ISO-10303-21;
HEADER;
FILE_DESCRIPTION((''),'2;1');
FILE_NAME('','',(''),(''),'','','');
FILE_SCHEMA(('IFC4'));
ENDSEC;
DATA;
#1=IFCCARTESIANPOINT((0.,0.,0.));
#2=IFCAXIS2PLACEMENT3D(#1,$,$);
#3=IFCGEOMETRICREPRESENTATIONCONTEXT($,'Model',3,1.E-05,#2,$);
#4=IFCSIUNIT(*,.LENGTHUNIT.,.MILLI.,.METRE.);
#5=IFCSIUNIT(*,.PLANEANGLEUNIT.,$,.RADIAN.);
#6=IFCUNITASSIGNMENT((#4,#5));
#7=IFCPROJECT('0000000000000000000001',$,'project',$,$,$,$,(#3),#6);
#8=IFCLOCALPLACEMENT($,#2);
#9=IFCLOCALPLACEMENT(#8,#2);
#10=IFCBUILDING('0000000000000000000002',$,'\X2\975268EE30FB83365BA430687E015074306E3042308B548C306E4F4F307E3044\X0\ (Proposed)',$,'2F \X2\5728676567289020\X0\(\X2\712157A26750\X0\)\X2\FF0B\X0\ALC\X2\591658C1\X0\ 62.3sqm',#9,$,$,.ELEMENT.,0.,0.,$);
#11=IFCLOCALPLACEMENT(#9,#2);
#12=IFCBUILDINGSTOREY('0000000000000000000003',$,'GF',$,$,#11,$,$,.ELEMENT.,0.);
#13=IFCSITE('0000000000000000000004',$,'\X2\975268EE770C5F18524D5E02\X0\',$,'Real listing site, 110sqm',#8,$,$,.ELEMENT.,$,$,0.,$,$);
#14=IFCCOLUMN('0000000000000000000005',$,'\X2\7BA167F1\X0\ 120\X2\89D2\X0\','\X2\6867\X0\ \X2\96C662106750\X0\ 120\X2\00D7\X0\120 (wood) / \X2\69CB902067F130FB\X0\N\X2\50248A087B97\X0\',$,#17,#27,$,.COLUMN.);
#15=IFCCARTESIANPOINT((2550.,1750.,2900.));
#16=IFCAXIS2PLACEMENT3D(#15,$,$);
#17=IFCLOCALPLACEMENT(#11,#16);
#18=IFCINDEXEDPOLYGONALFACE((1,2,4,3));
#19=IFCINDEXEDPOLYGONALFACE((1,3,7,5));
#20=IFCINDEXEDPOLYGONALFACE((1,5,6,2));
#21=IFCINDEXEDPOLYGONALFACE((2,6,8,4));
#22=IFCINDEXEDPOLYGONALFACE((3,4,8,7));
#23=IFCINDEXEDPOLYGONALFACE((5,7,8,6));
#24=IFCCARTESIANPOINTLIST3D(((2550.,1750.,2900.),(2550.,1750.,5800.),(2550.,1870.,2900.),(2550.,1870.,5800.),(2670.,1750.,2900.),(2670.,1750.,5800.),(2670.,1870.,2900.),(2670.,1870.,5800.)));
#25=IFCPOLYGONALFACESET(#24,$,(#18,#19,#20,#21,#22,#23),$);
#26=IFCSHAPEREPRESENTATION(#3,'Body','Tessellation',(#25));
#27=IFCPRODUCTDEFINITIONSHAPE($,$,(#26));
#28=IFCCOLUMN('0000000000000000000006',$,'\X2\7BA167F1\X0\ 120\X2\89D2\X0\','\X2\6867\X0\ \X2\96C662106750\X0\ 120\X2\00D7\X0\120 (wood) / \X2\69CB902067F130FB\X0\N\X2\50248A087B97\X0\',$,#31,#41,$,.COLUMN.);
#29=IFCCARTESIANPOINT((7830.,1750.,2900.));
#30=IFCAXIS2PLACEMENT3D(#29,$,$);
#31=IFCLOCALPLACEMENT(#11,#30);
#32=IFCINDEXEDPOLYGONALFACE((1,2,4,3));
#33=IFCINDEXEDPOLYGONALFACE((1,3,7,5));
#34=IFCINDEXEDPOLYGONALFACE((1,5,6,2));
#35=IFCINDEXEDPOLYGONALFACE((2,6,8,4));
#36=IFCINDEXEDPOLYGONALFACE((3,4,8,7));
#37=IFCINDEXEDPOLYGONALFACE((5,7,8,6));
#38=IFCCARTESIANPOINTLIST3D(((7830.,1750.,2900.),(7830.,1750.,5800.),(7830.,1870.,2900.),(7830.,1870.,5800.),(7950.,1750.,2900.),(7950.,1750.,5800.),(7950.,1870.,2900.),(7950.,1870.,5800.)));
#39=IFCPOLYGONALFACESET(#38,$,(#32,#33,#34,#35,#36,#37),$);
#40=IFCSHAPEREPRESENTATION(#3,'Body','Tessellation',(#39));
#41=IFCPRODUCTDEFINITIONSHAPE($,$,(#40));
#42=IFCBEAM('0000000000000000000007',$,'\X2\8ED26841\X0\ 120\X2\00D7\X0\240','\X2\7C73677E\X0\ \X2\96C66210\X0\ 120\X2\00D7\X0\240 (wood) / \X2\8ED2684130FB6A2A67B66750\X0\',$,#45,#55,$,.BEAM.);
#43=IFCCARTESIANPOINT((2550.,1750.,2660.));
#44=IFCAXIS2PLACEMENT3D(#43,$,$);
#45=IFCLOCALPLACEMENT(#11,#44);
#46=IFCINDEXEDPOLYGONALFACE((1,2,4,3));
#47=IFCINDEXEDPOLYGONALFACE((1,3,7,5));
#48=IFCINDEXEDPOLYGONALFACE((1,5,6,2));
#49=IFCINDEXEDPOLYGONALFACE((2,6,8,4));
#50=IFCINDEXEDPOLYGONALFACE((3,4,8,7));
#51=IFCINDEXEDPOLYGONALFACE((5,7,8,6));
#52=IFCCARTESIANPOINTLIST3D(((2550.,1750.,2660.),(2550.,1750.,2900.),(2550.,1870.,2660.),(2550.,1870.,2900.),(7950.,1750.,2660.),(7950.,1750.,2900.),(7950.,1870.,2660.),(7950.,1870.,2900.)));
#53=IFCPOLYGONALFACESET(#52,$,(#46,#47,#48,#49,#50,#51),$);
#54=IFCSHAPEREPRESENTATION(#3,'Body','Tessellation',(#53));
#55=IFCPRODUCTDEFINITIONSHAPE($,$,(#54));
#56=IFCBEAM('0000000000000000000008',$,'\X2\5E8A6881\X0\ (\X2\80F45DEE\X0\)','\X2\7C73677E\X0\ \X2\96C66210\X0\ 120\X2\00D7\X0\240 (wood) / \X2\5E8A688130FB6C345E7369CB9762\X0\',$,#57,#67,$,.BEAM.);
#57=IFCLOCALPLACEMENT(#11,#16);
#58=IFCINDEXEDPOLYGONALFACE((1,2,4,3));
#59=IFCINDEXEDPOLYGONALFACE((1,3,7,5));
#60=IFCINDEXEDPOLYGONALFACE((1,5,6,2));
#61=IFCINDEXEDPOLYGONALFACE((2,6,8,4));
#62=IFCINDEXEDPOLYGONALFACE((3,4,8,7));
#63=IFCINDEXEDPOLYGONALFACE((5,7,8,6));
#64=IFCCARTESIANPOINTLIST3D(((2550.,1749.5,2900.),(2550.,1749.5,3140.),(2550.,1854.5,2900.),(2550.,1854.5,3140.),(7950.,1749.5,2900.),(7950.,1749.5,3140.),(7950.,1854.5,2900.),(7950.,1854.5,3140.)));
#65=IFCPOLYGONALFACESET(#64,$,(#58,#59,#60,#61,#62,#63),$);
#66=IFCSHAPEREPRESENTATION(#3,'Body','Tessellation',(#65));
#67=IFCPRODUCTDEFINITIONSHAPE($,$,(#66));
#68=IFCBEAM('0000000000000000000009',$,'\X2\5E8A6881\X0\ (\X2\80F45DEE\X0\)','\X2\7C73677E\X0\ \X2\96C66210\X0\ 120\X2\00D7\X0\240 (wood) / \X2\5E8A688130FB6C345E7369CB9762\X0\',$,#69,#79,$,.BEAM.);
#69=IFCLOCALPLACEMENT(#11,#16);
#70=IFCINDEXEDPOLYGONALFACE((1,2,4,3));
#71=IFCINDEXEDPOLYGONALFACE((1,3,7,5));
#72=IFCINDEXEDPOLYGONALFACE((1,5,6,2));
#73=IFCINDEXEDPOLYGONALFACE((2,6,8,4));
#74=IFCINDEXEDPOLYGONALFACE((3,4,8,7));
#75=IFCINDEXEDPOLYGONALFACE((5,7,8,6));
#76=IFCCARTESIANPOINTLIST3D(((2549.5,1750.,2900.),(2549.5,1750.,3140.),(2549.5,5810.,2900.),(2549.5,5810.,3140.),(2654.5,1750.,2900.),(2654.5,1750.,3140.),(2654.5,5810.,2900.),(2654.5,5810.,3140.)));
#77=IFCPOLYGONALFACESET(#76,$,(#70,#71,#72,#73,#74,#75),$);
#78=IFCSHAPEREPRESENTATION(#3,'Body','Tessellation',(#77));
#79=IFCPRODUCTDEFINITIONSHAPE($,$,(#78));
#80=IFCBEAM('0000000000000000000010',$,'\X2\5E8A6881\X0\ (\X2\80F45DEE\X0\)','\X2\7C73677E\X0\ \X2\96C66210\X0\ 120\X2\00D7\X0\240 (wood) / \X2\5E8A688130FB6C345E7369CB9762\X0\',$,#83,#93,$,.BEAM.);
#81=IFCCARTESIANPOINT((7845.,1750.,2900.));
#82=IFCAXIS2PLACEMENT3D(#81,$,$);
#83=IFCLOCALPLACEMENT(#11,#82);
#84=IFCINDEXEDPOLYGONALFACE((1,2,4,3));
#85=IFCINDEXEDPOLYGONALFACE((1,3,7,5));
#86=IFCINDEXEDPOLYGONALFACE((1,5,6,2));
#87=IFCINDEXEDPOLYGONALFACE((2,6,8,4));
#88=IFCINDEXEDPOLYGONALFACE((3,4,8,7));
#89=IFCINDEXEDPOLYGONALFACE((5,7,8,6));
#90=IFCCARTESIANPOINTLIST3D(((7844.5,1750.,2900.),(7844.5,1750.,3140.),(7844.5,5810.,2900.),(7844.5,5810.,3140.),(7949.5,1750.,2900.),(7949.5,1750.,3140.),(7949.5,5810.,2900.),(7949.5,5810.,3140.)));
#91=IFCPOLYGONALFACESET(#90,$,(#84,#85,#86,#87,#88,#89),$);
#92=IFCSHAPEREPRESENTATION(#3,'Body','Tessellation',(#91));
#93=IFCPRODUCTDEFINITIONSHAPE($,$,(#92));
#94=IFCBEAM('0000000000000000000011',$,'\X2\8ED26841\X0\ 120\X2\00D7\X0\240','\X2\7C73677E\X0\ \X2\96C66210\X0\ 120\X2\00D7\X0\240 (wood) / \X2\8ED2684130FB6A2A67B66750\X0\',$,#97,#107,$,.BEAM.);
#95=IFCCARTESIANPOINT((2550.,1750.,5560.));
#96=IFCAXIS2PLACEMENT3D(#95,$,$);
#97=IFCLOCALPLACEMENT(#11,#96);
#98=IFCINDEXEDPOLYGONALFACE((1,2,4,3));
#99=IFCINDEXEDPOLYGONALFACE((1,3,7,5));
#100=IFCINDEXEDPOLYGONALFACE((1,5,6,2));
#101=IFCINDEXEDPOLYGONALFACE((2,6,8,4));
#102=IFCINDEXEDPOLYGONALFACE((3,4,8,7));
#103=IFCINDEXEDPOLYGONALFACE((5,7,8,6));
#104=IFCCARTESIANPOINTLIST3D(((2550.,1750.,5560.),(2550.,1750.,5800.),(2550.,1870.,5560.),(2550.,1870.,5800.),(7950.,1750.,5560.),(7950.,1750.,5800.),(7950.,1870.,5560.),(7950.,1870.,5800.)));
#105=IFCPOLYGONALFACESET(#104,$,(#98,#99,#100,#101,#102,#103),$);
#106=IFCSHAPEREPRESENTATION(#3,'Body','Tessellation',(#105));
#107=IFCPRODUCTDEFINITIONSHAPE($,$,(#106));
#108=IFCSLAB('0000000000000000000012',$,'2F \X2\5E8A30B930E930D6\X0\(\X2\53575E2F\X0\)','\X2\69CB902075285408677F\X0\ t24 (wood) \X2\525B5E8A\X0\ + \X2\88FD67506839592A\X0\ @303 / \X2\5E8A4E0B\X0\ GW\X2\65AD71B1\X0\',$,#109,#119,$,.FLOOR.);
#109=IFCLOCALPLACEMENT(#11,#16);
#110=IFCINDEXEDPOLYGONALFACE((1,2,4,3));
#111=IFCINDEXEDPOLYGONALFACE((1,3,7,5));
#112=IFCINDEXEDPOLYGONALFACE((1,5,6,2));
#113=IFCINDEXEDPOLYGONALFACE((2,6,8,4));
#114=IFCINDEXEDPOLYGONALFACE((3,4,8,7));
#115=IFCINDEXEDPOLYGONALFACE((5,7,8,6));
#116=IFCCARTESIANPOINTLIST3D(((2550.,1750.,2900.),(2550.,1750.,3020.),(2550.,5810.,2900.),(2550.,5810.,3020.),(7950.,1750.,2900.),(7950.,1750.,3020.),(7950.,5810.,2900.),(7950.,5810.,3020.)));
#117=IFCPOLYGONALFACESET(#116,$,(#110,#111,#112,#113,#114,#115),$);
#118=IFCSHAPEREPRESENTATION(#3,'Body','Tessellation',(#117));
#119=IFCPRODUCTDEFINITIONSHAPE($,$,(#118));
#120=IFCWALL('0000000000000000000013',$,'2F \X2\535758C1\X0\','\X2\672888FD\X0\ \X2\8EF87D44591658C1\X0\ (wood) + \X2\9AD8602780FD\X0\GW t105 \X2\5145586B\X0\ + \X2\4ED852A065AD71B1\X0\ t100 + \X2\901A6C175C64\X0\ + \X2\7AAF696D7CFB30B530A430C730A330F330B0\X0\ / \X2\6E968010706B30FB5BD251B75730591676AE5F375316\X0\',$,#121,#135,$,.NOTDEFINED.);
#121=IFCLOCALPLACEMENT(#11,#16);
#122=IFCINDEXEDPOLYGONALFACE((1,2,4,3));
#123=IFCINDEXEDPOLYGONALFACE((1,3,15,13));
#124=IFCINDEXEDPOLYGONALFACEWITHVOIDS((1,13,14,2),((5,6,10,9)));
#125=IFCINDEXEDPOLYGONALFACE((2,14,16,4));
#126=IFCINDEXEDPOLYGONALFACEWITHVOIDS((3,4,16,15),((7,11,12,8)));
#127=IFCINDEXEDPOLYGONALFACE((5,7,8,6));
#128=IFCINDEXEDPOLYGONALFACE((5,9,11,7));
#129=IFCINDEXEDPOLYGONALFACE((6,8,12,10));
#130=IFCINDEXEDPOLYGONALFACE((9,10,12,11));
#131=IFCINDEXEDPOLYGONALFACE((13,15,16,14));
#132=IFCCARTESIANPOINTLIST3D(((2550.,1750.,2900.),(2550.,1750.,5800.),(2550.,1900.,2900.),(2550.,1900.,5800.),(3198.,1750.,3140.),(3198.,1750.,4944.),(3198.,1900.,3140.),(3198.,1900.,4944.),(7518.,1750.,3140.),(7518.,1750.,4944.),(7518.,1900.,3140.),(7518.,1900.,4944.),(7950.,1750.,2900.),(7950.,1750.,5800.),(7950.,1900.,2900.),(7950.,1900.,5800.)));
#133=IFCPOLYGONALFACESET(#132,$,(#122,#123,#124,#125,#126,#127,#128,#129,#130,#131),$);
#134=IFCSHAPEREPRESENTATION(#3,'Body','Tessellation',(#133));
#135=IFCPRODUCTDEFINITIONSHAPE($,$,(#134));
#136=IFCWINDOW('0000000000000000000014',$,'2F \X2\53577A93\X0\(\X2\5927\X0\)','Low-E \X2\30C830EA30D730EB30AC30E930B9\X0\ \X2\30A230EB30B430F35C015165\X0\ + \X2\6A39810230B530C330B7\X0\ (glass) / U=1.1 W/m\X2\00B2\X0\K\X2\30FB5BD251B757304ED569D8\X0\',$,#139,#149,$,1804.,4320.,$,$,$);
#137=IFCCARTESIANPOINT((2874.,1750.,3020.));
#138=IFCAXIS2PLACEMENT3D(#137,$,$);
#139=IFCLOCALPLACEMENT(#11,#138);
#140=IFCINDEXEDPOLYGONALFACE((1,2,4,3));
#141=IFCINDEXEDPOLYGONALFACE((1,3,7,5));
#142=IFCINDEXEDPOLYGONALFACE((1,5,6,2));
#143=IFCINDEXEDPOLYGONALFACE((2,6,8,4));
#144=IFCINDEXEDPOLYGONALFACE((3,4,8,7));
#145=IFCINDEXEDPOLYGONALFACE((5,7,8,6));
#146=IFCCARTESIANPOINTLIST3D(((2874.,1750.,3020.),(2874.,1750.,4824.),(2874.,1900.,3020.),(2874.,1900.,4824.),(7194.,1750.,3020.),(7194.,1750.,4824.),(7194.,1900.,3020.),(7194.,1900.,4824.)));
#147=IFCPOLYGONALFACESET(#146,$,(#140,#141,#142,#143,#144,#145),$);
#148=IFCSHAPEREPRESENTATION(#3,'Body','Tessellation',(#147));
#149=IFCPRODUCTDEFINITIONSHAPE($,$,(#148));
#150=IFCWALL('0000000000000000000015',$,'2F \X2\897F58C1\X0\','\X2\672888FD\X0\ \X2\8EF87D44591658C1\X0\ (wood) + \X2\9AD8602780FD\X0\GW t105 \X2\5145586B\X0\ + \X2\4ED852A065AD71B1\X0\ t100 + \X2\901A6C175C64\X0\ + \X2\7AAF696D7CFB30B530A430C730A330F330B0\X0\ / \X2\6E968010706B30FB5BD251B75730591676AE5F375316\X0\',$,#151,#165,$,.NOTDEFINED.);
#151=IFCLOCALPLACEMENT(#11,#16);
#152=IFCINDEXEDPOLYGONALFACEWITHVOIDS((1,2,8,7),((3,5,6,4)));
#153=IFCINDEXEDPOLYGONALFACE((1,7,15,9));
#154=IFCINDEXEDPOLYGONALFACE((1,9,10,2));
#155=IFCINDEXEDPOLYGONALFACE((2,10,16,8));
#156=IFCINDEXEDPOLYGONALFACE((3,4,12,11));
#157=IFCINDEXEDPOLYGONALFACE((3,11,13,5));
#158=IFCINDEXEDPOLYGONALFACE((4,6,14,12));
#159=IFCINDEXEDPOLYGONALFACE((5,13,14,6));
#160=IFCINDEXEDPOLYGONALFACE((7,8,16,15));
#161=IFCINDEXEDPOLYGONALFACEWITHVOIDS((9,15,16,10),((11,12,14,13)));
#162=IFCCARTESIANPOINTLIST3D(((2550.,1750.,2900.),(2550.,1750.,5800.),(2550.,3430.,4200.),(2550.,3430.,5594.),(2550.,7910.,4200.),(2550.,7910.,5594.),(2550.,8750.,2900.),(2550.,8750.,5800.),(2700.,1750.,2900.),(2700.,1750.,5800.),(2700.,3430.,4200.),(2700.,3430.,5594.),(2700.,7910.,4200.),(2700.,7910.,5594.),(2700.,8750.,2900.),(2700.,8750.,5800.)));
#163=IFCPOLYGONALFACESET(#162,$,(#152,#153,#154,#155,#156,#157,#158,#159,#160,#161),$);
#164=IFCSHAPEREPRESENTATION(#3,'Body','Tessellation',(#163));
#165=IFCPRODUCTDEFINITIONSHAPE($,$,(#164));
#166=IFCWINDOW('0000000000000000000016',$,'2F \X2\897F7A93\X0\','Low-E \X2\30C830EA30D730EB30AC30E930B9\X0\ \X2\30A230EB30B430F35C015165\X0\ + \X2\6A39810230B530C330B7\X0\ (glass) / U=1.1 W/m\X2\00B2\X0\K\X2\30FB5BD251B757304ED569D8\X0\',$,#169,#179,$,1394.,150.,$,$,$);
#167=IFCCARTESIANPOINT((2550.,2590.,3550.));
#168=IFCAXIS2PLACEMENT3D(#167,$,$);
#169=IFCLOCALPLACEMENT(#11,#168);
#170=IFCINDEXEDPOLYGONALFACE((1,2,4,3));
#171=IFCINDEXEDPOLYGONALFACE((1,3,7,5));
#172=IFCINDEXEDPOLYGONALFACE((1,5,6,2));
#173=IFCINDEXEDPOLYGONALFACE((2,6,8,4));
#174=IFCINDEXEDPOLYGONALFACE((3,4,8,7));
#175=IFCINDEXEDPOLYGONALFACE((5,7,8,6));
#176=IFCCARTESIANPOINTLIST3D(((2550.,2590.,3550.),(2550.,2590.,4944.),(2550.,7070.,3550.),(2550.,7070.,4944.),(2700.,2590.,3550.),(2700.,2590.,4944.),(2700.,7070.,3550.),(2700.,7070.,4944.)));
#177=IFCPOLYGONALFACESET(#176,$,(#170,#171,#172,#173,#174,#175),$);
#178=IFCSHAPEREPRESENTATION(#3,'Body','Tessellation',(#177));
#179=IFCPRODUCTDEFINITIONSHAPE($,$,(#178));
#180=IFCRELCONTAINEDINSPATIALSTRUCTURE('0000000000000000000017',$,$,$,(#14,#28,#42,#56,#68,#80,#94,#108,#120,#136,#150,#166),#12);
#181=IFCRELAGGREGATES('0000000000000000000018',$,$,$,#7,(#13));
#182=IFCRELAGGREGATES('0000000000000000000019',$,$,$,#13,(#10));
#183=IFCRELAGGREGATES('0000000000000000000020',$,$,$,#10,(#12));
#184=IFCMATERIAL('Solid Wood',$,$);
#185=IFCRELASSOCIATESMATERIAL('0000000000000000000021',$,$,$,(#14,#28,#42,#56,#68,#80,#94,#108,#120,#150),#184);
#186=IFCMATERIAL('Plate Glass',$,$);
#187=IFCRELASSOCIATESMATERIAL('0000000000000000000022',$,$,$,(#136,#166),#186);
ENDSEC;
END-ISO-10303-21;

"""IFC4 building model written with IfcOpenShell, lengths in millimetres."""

from ifc_helpers import new_model, si_unit, frame, frame_2d, origin, place, context, project, spatial, rectangle, extrude, material, element, fill, save


model = new_model("IFC4")

# Units and contexts
model_context = context("Model", 3, precision=1e-05, world=origin())
ifc_project = project(units=[si_unit("LENGTHUNIT", "METRE", prefix="MILLI"), si_unit("PLANEANGLEUNIT", "RADIAN")], contexts=[model_context])

# Site, building, storey
site_placement = place(None, origin())
site = spatial("IfcSite", under=ifc_project, at=site_placement, Name="青森県弘前市", ObjectType="Real listing site, 110sqm", CompositionType="ELEMENT", RefElevation=0.0)
building_placement = place(site_placement, origin())
building = spatial("IfcBuilding", under=site, at=building_placement, Name="青森・茶室と縁側のある和の住まい (Proposed)", ObjectType="2F 在来木造(無垢材)＋ALC外壁 62.3sqm", CompositionType="ELEMENT", ElevationOfRefHeight=0.0, ElevationOfTerrain=0.0)
storey_placement = place(building_placement, origin())
storey = spatial("IfcBuildingStorey", under=building, at=storey_placement, Name="GF", CompositionType="ELEMENT", Elevation=0.0)

# Columns
ifc_material_1 = material(Name="Solid Wood")
column_1_placement = place(storey_placement, frame((2550.0, 1750.0, 2900.0)))
element("IfcColumn", 1, at=column_1_placement, inside=storey, material=ifc_material_1, Name="管柱 120角", Description="桧 集成材 120×120 (wood) / 構造柱・N値計算", PredefinedType="COLUMN", context=model_context, shape_type="SweptSolid", body=[
    extrude(rectangle(XDim=120.0, YDim=120.0, at=frame_2d((60.0, 60.0))), frame((2550.0, 1750.0, 2900.0)), (0.0, 0.0, 1.0), 2900.0),
])
column_2_placement = place(storey_placement, frame((7830.0, 1750.0, 2900.0)))
element("IfcColumn", 2, at=column_2_placement, inside=storey, material=ifc_material_1, Name="管柱 120角", Description="桧 集成材 120×120 (wood) / 構造柱・N値計算", PredefinedType="COLUMN", context=model_context, shape_type="SweptSolid", body=[
    extrude(rectangle(XDim=120.0, YDim=120.0, at=frame_2d((60.0, 60.0))), frame((7830.0, 1750.0, 2900.0)), (0.0, 0.0, 1.0), 2900.0),
])

# Beams
beam_1_placement = place(storey_placement, frame((2550.0, 1750.0, 2660.0)))
element("IfcBeam", 3, at=beam_1_placement, inside=storey, material=ifc_material_1, Name="軒桁 120×240", Description="米松 集成 120×240 (wood) / 軒桁・横架材", PredefinedType="BEAM", context=model_context, shape_type="SweptSolid", body=[
    extrude(rectangle(XDim=5400.0, YDim=120.0, at=frame_2d((2700.0, 60.0))), frame((2550.0, 1750.0, 2660.0)), (0.0, 0.0, 1.0), 240.0),
])
beam_2_placement = place(storey_placement, frame((2550.0, 1750.0, 2900.0)))
element("IfcBeam", 4, at=beam_2_placement, inside=storey, material=ifc_material_1, Name="床梁 (胴差)", Description="米松 集成 120×240 (wood) / 床梁・水平構面", PredefinedType="BEAM", context=model_context, shape_type="SweptSolid", body=[
    extrude(rectangle(XDim=5400.0, YDim=105.0, at=frame_2d((2700.0, 52.0))), frame((2550.0, 1750.0, 2900.0)), (0.0, 0.0, 1.0), 240.0),
])
beam_3_placement = place(storey_placement, frame((2550.0, 1750.0, 2900.0)))
element("IfcBeam", 5, at=beam_3_placement, inside=storey, material=ifc_material_1, Name="床梁 (胴差)", Description="米松 集成 120×240 (wood) / 床梁・水平構面", PredefinedType="BEAM", context=model_context, shape_type="SweptSolid", body=[
    extrude(rectangle(XDim=105.0, YDim=4060.0, at=frame_2d((52.0, 2030.0))), frame((2550.0, 1750.0, 2900.0)), (0.0, 0.0, 1.0), 240.0),
])
beam_4_placement = place(storey_placement, frame((7845.0, 1750.0, 2900.0)))
element("IfcBeam", 6, at=beam_4_placement, inside=storey, material=ifc_material_1, Name="床梁 (胴差)", Description="米松 集成 120×240 (wood) / 床梁・水平構面", PredefinedType="BEAM", context=model_context, shape_type="SweptSolid", body=[
    extrude(rectangle(XDim=105.0, YDim=4060.0, at=frame_2d((52.0, 2030.0))), frame((7845.0, 1750.0, 2900.0)), (0.0, 0.0, 1.0), 240.0),
])
beam_5_placement = place(storey_placement, frame((2550.0, 1750.0, 5560.0)))
element("IfcBeam", 7, at=beam_5_placement, inside=storey, material=ifc_material_1, Name="軒桁 120×240", Description="米松 集成 120×240 (wood) / 軒桁・横架材", PredefinedType="BEAM", context=model_context, shape_type="SweptSolid", body=[
    extrude(rectangle(XDim=5400.0, YDim=120.0, at=frame_2d((2700.0, 60.0))), frame((2550.0, 1750.0, 5560.0)), (0.0, 0.0, 1.0), 240.0),
])

# Slab
slab_placement = place(storey_placement, frame((2550.0, 1750.0, 2900.0)))
element("IfcSlab", 8, at=slab_placement, inside=storey, material=ifc_material_1, Name="2F 床スラブ(南帯)", Description="構造用合板 t24 (wood) 剛床 + 製材根太 @303 / 床下 GW断熱", PredefinedType="FLOOR", context=model_context, shape_type="SweptSolid", body=[
    extrude(rectangle(XDim=5400.0, YDim=4060.0, at=frame_2d((2700.0, 2030.0))), frame((2550.0, 1750.0, 2900.0)), (0.0, 0.0, 1.0), 120.0),
])

# Walls, openings, windows
wall_1_placement = place(storey_placement, frame((2550.0, 1750.0, 2900.0)))
wall_1 = element("IfcWall", 9, at=wall_1_placement, inside=storey, material=ifc_material_1, Name="2F 南壁", Description="木製 軸組外壁 (wood) + 高性能GW t105 充填 + 付加断熱 t100 + 通気層 + 窯業系サイディング / 準耐火・寒冷地外皮強化", PredefinedType="NOTDEFINED", context=model_context, shape_type="SweptSolid", body=[
    extrude(rectangle(XDim=5400.0, YDim=150.0, at=frame_2d((2700.0, 75.0))), frame((2550.0, 1750.0, 2900.0)), (0.0, 0.0, 1.0), 2900.0),
])
opening_1_placement = place(storey_placement, frame((2874.0, 1750.0, 3020.0)))
opening_1 = element("IfcOpeningElement", 10, at=opening_1_placement, cuts=wall_1, PredefinedType="NOTDEFINED", context=model_context, shape_type="SweptSolid", body=[
    extrude(rectangle(XDim=4320.0, YDim=150.0, at=frame_2d((2160.0, 75.0))), frame((2874.0, 1750.0, 3020.0)), (0.0, 0.0, 1.0), 1804.0),
])
ifc_material_2 = material(Name="Plate Glass")
window_1_placement = place(storey_placement, frame((2874.0, 1750.0, 3020.0)))
window_1 = element("IfcWindow", 11, at=window_1_placement, inside=storey, material=ifc_material_2, Name="2F 南窓(大)", Description="Low-E トリプルガラス アルゴン封入 + 樹脂サッシ (glass) / U=1.1 W/m²K・寒冷地仕様", OverallHeight=1804.0, OverallWidth=4320.0, context=model_context, shape_type="SweptSolid", body=[
    extrude(rectangle(XDim=4320.0, YDim=150.0, at=frame_2d((2160.0, 75.0))), frame((2874.0, 1750.0, 3020.0)), (0.0, 0.0, 1.0), 1804.0),
])
fill(opening_1, window_1)
wall_2_placement = place(storey_placement, frame((2550.0, 1750.0, 2900.0)))
wall_2 = element("IfcWall", 12, at=wall_2_placement, inside=storey, material=ifc_material_1, Name="2F 西壁", Description="木製 軸組外壁 (wood) + 高性能GW t105 充填 + 付加断熱 t100 + 通気層 + 窯業系サイディング / 準耐火・寒冷地外皮強化", PredefinedType="NOTDEFINED", context=model_context, shape_type="SweptSolid", body=[
    extrude(rectangle(XDim=150.0, YDim=7000.0, at=frame_2d((75.0, 3500.0))), frame((2550.0, 1750.0, 2900.0)), (0.0, 0.0, 1.0), 2900.0),
])
opening_2_placement = place(storey_placement, frame((2550.0, 2590.0, 3550.0)))
opening_2 = element("IfcOpeningElement", 13, at=opening_2_placement, cuts=wall_2, PredefinedType="NOTDEFINED", context=model_context, shape_type="SweptSolid", body=[
    extrude(rectangle(XDim=150.0, YDim=4480.0, at=frame_2d((75.0, 2240.0))), frame((2550.0, 2590.0, 3550.0)), (0.0, 0.0, 1.0), 1394.0),
])
window_2_placement = place(storey_placement, frame((2550.0, 2590.0, 3550.0)))
window_2 = element("IfcWindow", 14, at=window_2_placement, inside=storey, material=ifc_material_2, Name="2F 西窓", Description="Low-E トリプルガラス アルゴン封入 + 樹脂サッシ (glass) / U=1.1 W/m²K・寒冷地仕様", OverallHeight=1394.0, OverallWidth=150.0, context=model_context, shape_type="SweptSolid", body=[
    extrude(rectangle(XDim=150.0, YDim=4480.0, at=frame_2d((75.0, 2240.0))), frame((2550.0, 2590.0, 3550.0)), (0.0, 0.0, 1.0), 1394.0),
])
fill(opening_2, window_2)

save(model, "model.ifc")
